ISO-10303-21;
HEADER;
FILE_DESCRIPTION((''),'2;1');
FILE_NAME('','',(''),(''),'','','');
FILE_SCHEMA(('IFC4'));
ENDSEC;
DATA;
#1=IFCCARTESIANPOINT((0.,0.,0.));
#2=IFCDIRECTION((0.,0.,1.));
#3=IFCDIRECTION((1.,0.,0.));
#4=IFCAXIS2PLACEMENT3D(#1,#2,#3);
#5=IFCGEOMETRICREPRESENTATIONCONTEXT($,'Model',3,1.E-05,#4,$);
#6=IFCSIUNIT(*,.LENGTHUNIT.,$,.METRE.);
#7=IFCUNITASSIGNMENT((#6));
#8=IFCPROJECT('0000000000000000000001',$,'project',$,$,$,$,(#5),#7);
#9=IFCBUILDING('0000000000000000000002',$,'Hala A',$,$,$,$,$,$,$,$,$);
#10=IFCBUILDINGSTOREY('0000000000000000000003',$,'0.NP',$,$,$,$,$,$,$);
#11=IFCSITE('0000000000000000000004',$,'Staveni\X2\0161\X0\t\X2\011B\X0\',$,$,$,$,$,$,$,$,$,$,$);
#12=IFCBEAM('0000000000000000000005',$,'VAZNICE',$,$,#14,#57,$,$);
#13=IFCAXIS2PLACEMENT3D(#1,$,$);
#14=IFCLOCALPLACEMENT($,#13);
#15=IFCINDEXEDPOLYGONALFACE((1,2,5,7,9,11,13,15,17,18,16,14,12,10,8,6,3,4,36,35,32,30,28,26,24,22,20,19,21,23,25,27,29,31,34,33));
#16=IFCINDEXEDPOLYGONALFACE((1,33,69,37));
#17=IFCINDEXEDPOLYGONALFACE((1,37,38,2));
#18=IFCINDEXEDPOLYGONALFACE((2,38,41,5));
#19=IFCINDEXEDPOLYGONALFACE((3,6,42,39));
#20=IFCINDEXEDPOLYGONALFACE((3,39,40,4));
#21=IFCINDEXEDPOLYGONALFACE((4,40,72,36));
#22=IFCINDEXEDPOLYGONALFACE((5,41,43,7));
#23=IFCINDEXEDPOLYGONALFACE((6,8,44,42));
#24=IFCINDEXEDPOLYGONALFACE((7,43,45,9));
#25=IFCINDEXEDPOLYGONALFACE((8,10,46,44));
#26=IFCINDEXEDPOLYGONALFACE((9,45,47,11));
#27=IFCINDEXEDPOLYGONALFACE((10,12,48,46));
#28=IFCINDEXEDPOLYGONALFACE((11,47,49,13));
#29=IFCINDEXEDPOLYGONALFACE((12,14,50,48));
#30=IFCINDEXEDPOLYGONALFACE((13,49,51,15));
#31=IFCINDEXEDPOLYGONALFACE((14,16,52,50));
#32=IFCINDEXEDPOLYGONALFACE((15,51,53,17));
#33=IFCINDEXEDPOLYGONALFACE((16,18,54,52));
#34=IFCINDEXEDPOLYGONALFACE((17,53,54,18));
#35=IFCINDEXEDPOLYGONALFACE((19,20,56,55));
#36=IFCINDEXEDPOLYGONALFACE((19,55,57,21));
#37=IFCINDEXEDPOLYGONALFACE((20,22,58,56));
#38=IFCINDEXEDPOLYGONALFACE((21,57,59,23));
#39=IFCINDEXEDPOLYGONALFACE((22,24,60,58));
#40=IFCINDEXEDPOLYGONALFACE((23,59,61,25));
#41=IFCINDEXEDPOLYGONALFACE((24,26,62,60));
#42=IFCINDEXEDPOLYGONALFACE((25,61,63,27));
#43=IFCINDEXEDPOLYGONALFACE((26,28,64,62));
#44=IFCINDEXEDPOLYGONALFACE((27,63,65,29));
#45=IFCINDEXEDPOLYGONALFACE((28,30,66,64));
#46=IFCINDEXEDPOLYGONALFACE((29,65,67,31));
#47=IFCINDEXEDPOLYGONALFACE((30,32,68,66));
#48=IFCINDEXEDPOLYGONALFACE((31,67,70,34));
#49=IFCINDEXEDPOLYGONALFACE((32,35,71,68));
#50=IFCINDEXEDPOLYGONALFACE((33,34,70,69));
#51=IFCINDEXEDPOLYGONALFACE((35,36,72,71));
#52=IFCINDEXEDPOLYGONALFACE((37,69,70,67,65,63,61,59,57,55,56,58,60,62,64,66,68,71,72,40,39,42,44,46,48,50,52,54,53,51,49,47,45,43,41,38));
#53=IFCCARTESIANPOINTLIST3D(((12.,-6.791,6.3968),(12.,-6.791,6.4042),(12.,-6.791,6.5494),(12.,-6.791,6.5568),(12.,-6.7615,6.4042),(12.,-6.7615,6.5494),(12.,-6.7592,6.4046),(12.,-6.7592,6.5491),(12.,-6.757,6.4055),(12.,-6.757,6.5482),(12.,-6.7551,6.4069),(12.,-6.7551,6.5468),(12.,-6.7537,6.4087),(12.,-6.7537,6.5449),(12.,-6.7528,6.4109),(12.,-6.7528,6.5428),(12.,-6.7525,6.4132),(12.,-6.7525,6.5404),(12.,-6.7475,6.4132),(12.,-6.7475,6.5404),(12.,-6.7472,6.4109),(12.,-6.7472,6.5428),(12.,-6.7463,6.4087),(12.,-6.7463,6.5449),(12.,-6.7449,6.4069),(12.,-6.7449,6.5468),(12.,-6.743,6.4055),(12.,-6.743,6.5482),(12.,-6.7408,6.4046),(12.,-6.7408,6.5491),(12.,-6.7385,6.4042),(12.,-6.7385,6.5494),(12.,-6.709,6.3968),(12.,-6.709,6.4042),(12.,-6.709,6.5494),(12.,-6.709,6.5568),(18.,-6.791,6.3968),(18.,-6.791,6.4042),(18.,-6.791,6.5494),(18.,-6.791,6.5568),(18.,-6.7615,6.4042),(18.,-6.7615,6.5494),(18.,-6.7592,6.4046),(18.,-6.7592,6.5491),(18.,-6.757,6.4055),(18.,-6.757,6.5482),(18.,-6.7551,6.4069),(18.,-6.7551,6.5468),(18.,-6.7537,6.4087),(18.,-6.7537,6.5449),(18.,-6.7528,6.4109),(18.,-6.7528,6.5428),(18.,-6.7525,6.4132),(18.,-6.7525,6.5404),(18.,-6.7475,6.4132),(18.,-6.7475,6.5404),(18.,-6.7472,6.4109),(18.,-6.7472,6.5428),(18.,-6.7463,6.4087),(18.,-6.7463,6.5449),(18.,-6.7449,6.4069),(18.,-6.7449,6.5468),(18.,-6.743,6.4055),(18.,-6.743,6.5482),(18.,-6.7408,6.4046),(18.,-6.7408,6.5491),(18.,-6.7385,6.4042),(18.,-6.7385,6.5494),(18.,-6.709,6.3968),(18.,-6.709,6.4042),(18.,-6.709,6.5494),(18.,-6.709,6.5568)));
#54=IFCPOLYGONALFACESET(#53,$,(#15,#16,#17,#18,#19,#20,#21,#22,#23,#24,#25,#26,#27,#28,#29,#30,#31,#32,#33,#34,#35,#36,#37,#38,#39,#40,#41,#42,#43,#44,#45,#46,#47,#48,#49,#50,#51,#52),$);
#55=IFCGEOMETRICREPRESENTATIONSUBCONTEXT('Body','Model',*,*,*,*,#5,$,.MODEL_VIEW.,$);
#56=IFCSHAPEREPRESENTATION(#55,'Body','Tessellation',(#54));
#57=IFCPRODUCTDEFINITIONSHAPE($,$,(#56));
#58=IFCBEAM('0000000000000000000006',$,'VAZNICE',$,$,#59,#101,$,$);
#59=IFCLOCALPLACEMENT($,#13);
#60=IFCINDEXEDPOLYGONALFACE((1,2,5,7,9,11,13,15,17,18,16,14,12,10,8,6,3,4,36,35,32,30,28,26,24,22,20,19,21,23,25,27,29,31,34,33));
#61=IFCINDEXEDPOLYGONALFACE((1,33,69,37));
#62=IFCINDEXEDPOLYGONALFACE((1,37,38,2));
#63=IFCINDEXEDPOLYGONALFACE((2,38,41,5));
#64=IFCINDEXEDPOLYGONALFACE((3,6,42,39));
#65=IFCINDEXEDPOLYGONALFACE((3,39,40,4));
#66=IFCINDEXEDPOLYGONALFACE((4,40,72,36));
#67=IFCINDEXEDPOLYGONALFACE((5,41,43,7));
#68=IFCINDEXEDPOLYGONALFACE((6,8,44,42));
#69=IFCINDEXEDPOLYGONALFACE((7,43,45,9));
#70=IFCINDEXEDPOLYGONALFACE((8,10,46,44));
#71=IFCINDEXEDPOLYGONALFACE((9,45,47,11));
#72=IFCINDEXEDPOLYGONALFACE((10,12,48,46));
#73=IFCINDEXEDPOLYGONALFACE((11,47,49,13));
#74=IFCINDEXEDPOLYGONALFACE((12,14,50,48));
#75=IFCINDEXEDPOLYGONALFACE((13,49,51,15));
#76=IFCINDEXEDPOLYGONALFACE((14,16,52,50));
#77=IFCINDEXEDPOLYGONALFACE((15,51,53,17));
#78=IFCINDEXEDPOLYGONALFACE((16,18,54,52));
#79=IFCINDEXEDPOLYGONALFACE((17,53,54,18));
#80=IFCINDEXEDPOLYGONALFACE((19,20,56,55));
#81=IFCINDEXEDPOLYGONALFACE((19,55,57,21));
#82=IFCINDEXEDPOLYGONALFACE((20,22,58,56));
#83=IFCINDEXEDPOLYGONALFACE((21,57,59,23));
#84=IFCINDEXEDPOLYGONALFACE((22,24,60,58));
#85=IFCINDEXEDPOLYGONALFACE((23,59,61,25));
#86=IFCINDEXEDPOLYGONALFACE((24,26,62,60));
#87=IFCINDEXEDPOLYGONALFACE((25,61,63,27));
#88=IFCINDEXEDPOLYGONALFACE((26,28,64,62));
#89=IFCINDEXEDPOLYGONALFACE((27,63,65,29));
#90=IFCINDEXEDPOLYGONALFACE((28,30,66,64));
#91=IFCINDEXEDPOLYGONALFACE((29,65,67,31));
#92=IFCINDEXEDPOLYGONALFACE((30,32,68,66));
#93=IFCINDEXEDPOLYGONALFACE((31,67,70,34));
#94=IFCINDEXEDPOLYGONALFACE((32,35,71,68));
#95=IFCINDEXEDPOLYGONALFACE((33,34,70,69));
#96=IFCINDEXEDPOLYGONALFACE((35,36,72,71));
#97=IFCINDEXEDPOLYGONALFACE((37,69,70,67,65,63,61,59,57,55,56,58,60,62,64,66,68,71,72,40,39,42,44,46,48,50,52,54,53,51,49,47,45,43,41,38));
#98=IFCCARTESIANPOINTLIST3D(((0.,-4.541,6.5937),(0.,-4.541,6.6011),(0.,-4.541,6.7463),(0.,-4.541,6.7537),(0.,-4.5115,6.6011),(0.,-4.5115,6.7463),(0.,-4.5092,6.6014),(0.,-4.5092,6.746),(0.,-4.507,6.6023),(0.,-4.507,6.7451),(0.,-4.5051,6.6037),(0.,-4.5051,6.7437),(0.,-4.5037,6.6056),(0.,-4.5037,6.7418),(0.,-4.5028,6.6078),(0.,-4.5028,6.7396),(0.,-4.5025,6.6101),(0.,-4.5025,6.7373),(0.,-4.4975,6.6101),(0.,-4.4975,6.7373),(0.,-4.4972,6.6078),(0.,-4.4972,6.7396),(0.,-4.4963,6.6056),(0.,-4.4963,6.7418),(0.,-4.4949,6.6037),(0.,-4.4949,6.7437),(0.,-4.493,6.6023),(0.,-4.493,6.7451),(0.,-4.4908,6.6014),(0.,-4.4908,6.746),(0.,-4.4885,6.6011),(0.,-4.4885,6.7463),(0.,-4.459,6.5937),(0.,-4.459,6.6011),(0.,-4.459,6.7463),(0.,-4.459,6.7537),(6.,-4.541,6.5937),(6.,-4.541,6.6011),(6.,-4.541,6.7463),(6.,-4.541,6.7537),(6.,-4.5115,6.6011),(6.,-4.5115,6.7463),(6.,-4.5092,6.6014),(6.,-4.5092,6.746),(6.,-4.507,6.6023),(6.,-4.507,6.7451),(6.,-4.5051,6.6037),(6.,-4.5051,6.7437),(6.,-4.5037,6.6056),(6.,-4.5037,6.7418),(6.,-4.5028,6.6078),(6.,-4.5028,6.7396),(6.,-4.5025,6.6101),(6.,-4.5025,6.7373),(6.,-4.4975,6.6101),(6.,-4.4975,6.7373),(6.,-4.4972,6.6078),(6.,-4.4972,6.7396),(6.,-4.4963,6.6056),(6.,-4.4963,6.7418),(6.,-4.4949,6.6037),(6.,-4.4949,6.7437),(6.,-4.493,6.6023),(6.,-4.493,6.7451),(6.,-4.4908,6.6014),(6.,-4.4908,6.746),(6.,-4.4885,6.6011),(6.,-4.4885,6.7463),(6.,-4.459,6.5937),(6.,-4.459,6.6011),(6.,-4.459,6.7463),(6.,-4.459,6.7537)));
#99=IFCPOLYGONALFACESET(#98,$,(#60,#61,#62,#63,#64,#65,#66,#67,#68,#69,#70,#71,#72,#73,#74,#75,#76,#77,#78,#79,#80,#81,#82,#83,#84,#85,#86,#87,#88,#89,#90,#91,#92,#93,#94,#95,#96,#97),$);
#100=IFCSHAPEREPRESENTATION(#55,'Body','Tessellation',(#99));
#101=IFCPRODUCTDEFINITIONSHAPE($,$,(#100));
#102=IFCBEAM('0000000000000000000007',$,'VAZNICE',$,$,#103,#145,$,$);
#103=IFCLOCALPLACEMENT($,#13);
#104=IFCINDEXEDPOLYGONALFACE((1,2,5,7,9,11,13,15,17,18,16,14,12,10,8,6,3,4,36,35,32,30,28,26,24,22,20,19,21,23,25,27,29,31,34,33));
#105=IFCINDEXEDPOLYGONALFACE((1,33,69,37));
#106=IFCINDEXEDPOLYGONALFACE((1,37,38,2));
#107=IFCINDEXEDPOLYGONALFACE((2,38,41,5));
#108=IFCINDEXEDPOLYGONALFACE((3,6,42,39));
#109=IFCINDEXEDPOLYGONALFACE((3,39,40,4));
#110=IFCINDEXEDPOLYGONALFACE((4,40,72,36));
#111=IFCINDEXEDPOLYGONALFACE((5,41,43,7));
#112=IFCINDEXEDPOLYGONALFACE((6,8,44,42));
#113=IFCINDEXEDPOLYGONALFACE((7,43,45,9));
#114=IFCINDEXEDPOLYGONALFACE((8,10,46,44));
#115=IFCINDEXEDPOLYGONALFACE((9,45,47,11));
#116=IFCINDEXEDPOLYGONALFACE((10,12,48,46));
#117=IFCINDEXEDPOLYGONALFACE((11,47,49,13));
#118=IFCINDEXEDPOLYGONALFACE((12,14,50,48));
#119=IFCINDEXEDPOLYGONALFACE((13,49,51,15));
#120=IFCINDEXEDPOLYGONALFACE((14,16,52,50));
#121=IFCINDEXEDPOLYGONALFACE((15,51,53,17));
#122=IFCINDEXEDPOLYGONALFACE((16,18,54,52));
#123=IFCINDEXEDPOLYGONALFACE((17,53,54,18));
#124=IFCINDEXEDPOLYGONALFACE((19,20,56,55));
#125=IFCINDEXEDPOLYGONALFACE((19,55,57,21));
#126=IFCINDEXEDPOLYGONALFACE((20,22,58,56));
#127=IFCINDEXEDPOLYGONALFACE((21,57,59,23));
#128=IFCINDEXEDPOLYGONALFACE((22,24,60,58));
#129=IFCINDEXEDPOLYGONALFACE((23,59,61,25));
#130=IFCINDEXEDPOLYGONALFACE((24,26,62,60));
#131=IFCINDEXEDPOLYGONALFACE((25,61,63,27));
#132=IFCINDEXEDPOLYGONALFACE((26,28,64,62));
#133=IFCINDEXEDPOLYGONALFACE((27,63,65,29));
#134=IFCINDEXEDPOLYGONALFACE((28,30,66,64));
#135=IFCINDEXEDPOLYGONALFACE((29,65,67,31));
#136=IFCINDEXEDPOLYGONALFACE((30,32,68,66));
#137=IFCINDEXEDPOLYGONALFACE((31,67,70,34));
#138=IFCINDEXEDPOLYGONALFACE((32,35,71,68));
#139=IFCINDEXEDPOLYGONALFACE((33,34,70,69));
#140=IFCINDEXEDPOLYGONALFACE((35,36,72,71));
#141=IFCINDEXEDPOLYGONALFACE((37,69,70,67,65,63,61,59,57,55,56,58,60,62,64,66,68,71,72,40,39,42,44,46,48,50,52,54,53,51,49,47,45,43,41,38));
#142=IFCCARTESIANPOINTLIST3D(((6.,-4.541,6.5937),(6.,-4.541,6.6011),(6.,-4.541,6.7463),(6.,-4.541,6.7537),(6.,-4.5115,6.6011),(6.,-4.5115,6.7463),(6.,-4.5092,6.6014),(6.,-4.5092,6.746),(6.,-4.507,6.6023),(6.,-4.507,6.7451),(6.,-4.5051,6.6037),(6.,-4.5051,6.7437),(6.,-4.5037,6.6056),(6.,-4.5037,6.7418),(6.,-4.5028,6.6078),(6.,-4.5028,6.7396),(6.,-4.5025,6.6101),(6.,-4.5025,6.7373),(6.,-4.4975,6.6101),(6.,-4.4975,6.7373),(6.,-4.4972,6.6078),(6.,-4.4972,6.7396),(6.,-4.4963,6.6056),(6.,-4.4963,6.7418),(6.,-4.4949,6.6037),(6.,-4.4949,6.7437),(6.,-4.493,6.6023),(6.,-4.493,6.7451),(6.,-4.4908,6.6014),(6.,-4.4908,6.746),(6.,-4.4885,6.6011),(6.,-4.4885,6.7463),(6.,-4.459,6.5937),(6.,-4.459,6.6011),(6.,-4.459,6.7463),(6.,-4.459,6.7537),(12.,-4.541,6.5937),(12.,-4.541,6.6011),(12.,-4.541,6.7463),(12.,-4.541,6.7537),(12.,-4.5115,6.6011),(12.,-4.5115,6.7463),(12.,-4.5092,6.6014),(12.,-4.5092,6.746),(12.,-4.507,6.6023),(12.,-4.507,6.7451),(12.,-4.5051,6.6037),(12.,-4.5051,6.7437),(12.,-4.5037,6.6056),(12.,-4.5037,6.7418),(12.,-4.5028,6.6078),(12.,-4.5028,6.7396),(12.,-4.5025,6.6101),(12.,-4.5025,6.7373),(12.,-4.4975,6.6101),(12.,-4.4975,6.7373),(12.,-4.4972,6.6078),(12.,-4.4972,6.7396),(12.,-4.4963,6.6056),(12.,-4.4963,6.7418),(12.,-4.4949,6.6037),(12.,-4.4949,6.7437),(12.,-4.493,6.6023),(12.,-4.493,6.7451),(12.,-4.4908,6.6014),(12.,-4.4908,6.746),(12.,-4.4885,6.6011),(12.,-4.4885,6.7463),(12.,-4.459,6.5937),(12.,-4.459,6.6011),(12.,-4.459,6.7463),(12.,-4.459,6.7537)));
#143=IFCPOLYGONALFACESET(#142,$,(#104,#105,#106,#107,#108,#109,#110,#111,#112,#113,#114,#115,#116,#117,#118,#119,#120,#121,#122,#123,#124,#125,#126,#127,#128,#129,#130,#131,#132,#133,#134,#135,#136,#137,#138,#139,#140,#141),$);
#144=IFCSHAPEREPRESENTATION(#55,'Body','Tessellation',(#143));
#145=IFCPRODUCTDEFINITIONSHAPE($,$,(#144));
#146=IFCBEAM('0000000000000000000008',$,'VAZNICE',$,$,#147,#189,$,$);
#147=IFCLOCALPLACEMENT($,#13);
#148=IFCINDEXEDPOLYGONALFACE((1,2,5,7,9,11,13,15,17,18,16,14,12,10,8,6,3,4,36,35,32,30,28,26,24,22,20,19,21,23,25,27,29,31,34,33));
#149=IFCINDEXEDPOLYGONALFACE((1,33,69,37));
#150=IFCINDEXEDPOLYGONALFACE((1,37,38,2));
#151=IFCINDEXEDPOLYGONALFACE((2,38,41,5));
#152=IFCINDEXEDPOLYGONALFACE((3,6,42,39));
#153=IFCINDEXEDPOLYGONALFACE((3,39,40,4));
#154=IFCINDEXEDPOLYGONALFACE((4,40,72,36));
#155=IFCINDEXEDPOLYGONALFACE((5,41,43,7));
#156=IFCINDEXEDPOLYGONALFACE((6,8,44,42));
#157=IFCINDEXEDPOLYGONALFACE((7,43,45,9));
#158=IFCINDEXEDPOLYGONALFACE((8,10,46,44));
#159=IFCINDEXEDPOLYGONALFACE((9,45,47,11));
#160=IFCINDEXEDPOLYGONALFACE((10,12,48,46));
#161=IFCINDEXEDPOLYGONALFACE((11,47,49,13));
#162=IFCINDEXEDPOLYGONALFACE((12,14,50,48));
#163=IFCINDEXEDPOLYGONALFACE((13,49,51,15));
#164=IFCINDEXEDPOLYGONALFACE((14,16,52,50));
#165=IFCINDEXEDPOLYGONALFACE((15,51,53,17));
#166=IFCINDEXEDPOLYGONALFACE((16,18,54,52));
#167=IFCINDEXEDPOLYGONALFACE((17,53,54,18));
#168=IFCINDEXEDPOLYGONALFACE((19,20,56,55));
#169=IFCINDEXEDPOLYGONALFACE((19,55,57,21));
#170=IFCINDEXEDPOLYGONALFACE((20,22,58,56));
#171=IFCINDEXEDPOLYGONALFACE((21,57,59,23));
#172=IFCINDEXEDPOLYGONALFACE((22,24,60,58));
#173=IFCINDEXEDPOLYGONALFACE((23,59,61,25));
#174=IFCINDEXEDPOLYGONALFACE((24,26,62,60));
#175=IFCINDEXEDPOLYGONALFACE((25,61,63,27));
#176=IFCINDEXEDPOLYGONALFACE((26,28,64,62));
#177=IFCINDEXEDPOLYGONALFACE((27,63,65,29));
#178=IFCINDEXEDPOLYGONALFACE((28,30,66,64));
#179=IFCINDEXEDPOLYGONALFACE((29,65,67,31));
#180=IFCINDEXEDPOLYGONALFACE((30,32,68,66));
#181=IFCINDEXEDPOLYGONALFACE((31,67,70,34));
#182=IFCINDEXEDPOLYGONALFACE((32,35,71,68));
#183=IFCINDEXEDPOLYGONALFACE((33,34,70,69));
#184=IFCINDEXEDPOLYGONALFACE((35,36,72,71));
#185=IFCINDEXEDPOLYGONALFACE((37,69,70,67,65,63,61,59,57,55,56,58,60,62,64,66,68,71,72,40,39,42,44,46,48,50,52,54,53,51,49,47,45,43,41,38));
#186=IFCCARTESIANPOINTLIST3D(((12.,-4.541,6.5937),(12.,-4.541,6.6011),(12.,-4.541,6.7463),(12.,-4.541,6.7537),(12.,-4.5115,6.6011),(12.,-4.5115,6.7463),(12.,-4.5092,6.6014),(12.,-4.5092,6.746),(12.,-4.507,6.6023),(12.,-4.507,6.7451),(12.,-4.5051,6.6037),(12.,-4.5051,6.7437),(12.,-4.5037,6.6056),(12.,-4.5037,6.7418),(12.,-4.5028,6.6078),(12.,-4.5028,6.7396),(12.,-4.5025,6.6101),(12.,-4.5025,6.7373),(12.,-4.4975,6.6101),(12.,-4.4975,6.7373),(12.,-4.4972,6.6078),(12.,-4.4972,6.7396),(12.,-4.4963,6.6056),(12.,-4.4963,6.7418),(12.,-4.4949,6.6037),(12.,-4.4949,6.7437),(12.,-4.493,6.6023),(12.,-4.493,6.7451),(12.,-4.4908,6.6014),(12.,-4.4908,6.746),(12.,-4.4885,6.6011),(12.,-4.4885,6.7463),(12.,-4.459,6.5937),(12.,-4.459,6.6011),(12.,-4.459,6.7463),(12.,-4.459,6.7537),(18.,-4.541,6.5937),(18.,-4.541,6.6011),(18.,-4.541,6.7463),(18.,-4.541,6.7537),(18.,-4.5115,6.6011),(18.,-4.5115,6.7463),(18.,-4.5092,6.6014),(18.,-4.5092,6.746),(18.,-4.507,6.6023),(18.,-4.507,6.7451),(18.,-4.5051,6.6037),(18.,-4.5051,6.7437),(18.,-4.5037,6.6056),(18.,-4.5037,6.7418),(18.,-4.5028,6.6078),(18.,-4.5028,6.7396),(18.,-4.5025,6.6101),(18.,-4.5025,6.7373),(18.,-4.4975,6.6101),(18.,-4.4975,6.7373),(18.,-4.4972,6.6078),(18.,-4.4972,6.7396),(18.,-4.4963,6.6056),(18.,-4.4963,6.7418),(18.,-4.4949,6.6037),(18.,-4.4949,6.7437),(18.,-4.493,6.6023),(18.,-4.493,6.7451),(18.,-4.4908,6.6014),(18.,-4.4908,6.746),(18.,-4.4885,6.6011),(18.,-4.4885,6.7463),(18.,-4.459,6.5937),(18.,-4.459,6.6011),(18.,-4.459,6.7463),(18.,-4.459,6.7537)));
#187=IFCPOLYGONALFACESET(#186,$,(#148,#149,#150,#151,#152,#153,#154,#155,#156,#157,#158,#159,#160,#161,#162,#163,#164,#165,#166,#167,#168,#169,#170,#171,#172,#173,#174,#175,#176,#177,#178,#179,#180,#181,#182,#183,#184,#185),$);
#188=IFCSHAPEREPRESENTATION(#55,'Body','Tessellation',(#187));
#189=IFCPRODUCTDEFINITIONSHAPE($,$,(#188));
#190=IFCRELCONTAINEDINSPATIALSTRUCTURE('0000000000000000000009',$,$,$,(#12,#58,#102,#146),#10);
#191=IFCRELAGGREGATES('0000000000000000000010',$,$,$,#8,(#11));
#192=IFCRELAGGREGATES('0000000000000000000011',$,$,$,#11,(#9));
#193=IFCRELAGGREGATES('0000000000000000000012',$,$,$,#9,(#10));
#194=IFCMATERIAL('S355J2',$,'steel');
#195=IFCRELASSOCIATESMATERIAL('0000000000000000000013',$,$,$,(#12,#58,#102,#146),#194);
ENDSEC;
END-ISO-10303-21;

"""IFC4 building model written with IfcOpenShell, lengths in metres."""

from ifc_helpers import new_model, si_unit, frame, origin_with_axes, place, context, subcontext, project, spatial, i_section, extrude, material, element, save


model = new_model("IFC4")

# Units and contexts
model_context = context("Model", 3, precision=1e-05, world=origin_with_axes())
body_context = subcontext(model_context, "Body", "Model", "MODEL_VIEW")
ifc_project = project(units=[si_unit("LENGTHUNIT", "METRE")], contexts=[model_context])

# Site, building, storey
site = spatial("IfcSite", under=ifc_project, Name="Staveniště")
building = spatial("IfcBuilding", under=site, Name="Hala A")
storey = spatial("IfcBuildingStorey", under=building, Name="0.NP")

# Shared definitions
ifc_material = material(Name="S355J2", Category="steel")

# Beams
for number, where, z_axis, x_axis, name in (
    (1, (12.0, -6.75, 6.4768), (1.0, 0.0, 0.0), (0.0, 1.0, 0.0), "VAZNICE"),
    (2, (0.0, -4.5, 6.6737), (1.0, 0.0, 0.0), (0.0, 1.0, 0.0), "VAZNICE"),
    (3, (6.0, -4.5, 6.6737), (1.0, 0.0, 0.0), (0.0, 1.0, 0.0), "VAZNICE"),
    (4, (12.0, -4.5, 6.6737), (1.0, 0.0, 0.0), (0.0, 1.0, 0.0), "VAZNICE"),
):
    element("IfcBeam", number, at=place(None, frame(where, z_axis=z_axis, x_axis=x_axis)), inside=storey, material=ifc_material, Name=name, context=body_context, shape_type="SweptSolid", body=[
        extrude(i_section(OverallWidth=0.082, OverallDepth=0.16, WebThickness=0.005, FlangeThickness=0.0074, FilletRadius=0.009), origin_with_axes(), (0.0, 0.0, 1.0), 6.0),
    ])

save(model, "model.ifc")
